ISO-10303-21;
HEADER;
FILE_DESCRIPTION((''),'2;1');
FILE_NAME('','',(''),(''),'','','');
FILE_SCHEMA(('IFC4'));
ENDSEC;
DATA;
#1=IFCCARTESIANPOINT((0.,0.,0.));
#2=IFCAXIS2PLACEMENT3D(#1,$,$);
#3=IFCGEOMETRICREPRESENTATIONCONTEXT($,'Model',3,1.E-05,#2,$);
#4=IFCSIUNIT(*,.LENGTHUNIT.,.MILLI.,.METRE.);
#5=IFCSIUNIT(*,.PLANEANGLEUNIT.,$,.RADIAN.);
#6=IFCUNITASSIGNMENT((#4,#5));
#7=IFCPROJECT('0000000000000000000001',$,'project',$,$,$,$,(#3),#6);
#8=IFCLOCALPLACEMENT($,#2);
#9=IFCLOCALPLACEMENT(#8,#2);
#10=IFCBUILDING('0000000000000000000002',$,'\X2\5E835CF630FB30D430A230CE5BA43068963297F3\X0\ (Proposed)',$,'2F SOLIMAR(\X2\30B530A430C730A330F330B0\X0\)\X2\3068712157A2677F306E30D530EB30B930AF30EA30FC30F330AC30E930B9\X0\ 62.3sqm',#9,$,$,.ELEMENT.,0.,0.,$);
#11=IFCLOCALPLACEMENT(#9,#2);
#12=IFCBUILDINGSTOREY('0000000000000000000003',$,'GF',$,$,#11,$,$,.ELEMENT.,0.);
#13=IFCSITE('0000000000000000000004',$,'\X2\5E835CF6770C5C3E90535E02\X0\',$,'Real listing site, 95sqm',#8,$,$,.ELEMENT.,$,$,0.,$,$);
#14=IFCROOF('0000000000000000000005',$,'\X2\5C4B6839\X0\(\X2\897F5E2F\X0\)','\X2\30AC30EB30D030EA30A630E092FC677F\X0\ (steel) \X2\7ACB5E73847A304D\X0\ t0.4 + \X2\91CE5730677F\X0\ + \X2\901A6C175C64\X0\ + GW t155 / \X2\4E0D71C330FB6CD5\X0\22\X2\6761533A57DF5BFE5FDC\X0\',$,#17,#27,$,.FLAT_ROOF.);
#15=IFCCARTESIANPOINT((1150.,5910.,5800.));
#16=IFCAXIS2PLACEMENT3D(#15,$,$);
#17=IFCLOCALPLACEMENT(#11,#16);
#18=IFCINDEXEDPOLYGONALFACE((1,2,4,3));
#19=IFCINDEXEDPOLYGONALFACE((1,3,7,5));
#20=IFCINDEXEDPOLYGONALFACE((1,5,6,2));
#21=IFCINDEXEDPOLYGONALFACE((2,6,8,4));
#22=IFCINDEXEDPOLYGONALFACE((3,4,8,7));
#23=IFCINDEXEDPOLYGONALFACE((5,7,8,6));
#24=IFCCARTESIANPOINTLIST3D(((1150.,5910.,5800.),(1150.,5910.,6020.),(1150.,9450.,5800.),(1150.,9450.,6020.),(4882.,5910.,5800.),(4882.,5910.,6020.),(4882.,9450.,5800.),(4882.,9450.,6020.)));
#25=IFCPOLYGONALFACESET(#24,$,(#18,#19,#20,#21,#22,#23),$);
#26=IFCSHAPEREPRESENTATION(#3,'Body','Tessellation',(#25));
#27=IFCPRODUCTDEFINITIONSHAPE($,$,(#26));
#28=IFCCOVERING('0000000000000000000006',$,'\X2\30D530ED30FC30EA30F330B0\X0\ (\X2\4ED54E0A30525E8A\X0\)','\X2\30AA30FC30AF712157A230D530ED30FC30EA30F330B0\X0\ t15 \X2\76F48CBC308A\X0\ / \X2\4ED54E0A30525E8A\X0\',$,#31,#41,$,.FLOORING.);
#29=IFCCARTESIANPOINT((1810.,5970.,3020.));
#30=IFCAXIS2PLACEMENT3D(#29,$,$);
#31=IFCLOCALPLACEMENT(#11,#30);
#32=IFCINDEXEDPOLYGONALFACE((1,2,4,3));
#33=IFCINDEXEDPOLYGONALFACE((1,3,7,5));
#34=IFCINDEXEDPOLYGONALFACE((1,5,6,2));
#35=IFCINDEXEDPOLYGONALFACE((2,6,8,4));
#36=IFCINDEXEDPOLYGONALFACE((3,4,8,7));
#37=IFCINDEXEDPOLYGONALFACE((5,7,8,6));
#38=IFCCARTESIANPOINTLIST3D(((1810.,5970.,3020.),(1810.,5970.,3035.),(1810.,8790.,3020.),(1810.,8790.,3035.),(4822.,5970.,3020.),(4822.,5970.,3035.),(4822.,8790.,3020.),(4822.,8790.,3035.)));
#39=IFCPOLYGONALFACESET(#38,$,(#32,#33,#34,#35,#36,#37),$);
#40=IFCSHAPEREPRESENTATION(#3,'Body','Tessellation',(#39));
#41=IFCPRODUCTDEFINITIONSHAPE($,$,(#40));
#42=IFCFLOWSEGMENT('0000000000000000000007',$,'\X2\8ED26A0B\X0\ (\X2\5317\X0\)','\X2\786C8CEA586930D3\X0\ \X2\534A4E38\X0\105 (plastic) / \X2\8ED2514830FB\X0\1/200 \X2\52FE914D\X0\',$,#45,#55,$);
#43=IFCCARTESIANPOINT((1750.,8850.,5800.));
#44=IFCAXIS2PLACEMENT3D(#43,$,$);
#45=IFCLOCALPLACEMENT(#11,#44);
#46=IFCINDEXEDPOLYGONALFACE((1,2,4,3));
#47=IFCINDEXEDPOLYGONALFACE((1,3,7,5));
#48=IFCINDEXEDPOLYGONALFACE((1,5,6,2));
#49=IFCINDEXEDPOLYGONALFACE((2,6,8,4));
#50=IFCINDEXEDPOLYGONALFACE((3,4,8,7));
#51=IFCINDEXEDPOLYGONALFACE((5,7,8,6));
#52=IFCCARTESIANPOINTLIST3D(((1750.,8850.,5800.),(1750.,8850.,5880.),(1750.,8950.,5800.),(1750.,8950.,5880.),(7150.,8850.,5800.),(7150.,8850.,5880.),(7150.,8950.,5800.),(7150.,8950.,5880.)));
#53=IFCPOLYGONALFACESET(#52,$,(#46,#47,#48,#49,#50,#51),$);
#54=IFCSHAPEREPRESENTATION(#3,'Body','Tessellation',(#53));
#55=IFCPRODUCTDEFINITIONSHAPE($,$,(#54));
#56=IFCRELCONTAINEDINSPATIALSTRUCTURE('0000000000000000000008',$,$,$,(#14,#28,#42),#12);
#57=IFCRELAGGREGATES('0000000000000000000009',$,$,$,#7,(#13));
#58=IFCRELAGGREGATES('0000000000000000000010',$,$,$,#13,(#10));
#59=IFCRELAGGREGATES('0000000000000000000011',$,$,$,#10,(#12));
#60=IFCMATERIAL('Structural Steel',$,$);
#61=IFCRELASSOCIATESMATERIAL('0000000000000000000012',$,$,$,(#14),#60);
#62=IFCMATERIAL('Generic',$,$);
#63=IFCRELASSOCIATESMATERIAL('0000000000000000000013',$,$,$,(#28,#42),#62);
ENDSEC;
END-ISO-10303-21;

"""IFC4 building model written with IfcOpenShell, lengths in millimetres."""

from ifc_helpers import new_model, si_unit, frame, frame_2d, origin, place, context, project, spatial, rectangle, extrude, material, element, save


model = new_model("IFC4")

# Units and contexts
model_context = context("Model", 3, precision=1e-05, world=origin())
ifc_project = project(units=[si_unit("LENGTHUNIT", "METRE", prefix="MILLI"), si_unit("PLANEANGLEUNIT", "RADIAN")], contexts=[model_context])

# Site, building, storey
site_placement = place(None, origin())
site = spatial("IfcSite", under=ifc_project, at=site_placement, Name="広島県尾道市", ObjectType="Real listing site, 95sqm", CompositionType="ELEMENT", RefElevation=0.0)
building_placement = place(site_placement, origin())
building = spatial("IfcBuilding", under=site, at=building_placement, Name="広島・ピアノ室と防音 (Proposed)", ObjectType="2F SOLIMAR(サイディング)と無垢板のフルスクリーンガラス 62.3sqm", CompositionType="ELEMENT", ElevationOfRefHeight=0.0, ElevationOfTerrain=0.0)
storey_placement = place(building_placement, origin())
storey = spatial("IfcBuildingStorey", under=building, at=storey_placement, Name="GF", CompositionType="ELEMENT", Elevation=0.0)

# Roof
ifc_material_1 = material(Name="Structural Steel")
for number, where, name in (
    (1, (1150.0, 5910.0, 5800.0), "屋根(西帯)"),
):
    element("IfcRoof", number, at=place(storey_placement, frame(where)), inside=storey, material=ifc_material_1, Name=name, Description="ガルバリウム鋼板 (steel) 立平葺き t0.4 + 野地板 + 通気層 + GW t155 / 不燃・法22条区域対応", PredefinedType="FLAT_ROOF", context=model_context, shape_type="SweptSolid", body=[
        extrude(rectangle(XDim=3732.0, YDim=3540.0, at=frame_2d((1866.0, 1770.0))), frame((1150.0, 5910.0, 5800.0)), (0.0, 0.0, 1.0), 220.0),
    ])

# Covering
ifc_material_2 = material(Name="Generic")
covering_placement = place(storey_placement, frame((1810.0, 5970.0, 3020.0)))
element("IfcCovering", 2, at=covering_placement, inside=storey, material=ifc_material_2, Name="フローリング (仕上げ床)", Description="オーク無垢フローリング t15 直貼り / 仕上げ床", PredefinedType="FLOORING", context=model_context, shape_type="SweptSolid", body=[
    extrude(rectangle(XDim=3012.0, YDim=2820.0, at=frame_2d((1506.0, 1410.0))), frame((1810.0, 5970.0, 3020.0)), (0.0, 0.0, 1.0), 15.0),
])

# Flow segment
flow_segment_placement = place(storey_placement, frame((1750.0, 8850.0, 5800.0)))
element("IfcFlowSegment", 3, at=flow_segment_placement, inside=storey, material=ifc_material_2, Name="軒樋 (北)", Description="硬質塩ビ 半丸105 (plastic) / 軒先・1/200 勾配", context=model_context, shape_type="SweptSolid", body=[
    extrude(rectangle(XDim=5400.0, YDim=100.0, at=frame_2d((2700.0, 50.0))), frame((1750.0, 8850.0, 5800.0)), (0.0, 0.0, 1.0), 80.0),
])

save(model, "model.ifc")
